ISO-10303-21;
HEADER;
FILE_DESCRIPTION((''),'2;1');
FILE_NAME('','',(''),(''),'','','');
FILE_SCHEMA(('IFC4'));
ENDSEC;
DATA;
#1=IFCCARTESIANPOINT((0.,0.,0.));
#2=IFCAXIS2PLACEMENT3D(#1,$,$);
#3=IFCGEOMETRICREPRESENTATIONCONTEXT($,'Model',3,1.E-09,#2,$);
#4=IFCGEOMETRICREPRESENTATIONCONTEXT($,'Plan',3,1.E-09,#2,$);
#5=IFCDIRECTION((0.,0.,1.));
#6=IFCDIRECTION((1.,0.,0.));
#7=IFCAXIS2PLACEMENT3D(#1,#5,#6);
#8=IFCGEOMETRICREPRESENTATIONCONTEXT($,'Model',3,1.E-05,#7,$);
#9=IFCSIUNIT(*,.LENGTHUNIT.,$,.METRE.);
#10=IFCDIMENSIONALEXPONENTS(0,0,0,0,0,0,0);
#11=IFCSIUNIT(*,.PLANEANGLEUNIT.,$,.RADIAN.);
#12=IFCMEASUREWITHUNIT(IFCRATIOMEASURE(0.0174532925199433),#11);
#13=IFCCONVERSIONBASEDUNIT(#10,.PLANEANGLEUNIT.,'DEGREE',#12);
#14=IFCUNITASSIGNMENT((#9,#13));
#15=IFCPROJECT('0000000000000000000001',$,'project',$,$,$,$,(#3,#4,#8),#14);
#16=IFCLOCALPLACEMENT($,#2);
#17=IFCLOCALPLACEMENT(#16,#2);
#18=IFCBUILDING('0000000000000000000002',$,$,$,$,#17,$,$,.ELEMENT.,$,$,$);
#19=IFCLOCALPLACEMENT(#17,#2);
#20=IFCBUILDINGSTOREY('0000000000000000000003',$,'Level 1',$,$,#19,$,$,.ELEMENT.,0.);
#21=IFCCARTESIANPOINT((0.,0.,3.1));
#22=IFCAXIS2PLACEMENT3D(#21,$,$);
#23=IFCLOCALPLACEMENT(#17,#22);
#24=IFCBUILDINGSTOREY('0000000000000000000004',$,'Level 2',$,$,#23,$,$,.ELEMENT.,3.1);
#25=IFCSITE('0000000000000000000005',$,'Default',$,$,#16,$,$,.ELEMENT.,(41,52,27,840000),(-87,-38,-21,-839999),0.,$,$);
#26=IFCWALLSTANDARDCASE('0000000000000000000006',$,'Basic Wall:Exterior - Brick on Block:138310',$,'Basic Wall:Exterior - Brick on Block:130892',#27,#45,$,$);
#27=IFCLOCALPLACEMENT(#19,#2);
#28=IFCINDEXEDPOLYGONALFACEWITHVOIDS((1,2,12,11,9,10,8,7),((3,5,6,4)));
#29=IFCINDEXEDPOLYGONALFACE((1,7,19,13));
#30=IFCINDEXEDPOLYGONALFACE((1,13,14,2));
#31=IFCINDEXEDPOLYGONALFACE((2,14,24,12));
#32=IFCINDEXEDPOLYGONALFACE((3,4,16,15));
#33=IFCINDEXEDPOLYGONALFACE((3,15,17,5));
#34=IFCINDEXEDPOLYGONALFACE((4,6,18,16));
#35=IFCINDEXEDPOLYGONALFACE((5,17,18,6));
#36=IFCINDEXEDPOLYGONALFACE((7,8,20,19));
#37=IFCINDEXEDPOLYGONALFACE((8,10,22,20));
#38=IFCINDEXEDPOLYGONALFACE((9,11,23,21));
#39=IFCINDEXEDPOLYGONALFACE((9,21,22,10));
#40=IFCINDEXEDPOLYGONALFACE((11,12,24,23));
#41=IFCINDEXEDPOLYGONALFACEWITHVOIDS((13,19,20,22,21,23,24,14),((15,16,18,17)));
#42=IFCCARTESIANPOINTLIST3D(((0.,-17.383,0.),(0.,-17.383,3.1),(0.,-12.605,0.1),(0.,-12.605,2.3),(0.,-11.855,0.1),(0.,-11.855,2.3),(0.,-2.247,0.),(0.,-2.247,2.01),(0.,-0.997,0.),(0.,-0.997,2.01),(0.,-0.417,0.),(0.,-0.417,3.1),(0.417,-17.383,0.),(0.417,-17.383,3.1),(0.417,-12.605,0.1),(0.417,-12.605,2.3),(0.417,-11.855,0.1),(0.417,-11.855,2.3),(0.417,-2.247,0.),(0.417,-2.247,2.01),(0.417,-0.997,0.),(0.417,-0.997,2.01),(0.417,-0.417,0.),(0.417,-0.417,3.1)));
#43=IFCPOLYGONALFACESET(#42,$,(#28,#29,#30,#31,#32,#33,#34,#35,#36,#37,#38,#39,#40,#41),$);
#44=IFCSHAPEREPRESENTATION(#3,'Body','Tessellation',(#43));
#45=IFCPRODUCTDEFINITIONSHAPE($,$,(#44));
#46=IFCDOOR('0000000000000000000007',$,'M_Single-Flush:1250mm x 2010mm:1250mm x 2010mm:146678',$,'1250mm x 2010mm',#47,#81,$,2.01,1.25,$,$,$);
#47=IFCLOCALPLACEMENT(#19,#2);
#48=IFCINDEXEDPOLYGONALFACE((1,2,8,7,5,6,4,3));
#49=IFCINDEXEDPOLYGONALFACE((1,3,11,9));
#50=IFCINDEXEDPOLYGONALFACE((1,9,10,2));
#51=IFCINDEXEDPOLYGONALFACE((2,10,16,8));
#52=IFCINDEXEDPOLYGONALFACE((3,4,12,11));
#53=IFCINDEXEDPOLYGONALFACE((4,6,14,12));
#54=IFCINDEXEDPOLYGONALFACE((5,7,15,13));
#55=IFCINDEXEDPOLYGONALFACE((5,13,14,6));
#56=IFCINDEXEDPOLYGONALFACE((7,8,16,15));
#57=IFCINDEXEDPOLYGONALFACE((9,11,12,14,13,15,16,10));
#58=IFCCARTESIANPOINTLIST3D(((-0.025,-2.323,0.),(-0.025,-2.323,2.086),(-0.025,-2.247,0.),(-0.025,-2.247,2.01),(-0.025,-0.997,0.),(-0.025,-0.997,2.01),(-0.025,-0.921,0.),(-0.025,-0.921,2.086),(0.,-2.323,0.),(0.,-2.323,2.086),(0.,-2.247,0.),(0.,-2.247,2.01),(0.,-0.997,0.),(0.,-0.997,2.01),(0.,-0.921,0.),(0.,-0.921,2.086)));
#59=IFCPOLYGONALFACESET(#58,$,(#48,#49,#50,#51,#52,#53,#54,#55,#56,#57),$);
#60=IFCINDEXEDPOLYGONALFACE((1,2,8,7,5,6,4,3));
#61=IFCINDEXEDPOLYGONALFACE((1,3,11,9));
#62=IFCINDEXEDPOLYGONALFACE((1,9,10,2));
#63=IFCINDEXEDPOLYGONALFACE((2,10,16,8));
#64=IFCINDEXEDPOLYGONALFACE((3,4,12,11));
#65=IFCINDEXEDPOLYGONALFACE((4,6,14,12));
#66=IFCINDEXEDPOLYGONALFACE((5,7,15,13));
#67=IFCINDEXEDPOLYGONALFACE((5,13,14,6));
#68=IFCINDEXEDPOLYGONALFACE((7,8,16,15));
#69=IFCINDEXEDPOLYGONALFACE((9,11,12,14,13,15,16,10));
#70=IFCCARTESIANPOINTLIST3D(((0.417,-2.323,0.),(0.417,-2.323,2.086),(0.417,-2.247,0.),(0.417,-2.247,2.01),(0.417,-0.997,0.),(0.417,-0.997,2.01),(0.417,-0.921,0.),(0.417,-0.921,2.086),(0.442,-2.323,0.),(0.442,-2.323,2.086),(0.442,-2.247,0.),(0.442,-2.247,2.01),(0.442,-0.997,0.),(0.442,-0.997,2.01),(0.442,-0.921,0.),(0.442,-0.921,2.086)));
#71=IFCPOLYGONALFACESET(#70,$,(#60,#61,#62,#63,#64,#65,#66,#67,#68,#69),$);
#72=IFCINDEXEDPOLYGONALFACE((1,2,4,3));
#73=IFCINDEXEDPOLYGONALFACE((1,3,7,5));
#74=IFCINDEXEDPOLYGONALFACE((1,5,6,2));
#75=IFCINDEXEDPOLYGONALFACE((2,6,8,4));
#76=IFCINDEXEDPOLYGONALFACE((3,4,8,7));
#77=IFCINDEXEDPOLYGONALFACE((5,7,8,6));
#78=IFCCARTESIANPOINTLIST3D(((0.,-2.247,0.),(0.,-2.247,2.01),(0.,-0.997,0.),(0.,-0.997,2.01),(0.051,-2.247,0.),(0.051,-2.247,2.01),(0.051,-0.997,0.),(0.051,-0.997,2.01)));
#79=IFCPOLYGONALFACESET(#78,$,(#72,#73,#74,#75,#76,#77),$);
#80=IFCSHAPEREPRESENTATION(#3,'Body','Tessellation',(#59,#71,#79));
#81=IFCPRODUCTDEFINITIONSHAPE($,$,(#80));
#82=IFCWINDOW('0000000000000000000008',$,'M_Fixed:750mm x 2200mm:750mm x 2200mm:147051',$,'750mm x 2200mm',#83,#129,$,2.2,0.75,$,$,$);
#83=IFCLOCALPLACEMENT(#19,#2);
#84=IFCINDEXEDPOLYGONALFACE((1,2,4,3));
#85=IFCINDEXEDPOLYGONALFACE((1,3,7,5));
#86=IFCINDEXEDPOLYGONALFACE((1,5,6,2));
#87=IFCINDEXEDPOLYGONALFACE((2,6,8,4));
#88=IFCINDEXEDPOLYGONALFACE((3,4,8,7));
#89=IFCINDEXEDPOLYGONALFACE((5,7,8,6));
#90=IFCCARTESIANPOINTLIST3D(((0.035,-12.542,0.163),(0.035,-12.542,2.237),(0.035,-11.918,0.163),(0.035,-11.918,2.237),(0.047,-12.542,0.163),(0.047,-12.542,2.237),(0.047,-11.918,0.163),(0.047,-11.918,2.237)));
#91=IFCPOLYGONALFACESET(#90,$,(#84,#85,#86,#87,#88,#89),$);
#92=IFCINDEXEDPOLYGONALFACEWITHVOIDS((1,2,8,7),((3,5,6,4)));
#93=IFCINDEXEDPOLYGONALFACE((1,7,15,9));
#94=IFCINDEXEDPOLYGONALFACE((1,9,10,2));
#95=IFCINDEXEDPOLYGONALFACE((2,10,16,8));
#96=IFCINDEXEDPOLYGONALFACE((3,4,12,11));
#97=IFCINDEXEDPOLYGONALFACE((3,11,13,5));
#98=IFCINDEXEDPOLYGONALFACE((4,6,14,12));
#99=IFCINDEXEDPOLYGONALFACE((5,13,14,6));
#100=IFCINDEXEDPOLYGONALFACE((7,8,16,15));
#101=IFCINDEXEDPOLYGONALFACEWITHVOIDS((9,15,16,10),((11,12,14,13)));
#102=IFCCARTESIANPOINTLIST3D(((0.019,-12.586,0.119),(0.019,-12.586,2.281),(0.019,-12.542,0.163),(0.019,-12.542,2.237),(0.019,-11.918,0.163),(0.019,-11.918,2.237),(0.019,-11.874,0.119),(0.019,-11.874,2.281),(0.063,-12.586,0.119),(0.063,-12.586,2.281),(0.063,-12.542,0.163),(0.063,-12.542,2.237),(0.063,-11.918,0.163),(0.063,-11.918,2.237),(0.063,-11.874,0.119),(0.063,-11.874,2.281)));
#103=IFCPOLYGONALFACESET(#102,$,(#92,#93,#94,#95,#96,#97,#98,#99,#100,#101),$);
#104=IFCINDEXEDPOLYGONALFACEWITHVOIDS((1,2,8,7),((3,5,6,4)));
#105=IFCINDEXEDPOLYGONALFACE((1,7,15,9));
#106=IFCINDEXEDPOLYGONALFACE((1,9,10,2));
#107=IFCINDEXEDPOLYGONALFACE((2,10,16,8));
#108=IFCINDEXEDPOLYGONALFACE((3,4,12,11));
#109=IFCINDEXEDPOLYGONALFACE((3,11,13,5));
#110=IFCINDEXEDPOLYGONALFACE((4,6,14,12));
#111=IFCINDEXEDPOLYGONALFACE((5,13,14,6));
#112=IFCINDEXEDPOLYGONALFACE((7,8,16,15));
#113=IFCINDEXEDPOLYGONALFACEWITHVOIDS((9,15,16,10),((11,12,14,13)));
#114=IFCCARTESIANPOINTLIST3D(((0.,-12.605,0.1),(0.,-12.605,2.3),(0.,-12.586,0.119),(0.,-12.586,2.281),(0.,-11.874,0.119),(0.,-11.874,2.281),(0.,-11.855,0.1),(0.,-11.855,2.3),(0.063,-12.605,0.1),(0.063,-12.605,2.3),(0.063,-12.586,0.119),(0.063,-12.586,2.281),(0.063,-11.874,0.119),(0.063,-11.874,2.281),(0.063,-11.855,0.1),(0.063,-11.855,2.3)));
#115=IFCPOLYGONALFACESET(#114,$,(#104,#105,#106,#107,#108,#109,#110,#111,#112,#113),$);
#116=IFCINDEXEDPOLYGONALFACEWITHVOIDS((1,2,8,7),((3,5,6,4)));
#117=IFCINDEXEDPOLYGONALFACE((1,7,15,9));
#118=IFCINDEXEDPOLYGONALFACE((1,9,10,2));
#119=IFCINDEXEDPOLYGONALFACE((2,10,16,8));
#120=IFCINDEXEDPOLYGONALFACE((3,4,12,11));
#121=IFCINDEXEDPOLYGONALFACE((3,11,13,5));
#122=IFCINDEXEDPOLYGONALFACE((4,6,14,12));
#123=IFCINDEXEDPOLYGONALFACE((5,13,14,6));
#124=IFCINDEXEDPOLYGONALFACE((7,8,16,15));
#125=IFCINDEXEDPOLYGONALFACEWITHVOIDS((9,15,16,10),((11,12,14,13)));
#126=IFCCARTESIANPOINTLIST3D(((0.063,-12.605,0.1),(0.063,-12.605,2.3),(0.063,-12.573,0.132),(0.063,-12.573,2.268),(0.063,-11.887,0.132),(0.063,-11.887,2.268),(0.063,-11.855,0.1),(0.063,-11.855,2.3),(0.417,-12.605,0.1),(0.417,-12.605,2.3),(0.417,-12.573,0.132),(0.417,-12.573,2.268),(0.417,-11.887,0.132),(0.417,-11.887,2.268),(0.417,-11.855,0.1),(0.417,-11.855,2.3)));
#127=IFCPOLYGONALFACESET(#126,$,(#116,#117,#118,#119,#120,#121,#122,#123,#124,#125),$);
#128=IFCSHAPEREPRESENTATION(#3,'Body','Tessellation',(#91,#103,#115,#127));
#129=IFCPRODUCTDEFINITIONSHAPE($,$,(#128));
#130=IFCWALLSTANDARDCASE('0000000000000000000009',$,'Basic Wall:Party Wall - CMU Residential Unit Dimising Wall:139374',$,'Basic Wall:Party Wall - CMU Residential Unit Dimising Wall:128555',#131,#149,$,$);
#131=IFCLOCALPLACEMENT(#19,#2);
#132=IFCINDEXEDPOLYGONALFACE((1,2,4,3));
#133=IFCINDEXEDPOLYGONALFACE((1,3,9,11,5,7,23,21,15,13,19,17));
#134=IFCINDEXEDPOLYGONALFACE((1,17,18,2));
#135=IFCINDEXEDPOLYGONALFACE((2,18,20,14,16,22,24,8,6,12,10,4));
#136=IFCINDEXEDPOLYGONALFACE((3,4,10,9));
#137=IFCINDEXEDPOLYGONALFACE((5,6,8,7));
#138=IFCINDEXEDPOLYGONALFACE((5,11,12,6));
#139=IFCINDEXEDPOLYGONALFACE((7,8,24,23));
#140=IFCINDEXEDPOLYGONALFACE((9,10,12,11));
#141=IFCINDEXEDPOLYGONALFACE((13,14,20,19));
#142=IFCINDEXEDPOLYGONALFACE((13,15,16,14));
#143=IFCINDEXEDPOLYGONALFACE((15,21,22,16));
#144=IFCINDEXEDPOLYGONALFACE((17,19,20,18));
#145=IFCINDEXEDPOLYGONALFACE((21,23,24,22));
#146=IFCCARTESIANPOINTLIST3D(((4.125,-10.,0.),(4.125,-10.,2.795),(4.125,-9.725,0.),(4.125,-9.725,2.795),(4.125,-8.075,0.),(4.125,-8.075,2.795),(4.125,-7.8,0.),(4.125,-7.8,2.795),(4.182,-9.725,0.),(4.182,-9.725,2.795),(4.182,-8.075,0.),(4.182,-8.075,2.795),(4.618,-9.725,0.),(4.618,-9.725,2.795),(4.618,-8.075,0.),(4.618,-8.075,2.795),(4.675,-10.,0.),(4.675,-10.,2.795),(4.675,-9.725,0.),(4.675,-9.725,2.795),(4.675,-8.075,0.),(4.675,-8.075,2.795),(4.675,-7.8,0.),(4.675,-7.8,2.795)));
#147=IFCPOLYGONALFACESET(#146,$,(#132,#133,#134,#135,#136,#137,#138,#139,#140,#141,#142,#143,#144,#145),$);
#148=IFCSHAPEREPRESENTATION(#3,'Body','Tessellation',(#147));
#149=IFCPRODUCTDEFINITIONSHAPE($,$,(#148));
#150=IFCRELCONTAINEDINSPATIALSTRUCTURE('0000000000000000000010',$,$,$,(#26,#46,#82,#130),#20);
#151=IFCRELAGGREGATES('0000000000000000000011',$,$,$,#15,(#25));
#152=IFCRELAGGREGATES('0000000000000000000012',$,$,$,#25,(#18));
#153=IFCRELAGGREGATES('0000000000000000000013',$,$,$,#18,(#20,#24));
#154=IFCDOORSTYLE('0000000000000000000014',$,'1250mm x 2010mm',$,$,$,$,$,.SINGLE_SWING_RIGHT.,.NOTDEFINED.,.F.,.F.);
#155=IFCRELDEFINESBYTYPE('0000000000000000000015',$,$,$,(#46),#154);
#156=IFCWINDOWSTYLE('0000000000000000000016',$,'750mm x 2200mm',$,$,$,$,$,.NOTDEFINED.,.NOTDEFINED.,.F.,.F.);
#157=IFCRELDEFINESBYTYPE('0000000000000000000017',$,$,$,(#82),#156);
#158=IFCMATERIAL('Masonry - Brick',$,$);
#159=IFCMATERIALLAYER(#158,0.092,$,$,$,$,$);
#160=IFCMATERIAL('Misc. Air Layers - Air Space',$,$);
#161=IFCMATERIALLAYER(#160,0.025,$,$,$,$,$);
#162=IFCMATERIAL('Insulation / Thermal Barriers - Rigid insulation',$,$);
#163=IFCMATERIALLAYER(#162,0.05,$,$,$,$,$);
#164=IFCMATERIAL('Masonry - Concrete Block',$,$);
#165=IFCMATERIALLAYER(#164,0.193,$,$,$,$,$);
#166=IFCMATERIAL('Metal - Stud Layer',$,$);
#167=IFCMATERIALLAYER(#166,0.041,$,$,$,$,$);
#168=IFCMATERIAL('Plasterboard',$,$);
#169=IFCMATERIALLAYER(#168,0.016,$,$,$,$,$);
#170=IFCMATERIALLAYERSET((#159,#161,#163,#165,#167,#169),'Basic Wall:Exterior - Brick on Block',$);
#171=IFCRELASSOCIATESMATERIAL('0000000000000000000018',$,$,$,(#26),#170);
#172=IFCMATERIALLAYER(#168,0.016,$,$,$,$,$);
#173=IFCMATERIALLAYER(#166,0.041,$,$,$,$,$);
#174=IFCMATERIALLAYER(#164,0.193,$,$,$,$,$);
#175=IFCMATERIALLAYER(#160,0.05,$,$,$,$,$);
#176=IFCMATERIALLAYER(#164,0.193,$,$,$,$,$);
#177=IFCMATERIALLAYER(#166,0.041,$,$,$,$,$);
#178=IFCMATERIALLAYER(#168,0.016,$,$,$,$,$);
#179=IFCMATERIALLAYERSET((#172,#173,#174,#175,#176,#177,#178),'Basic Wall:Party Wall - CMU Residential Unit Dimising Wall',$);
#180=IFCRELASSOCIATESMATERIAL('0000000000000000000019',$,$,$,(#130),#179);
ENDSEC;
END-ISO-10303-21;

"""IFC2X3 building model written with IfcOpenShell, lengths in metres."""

from ifc_helpers import new_model, entity, si_unit, converted_unit, frame, frame_2d, origin, origin_with_axes, origin_2d_with_axis, place, context, project, spatial, polyline, rectangle, outline, extrude, clip, bounded_halfspace, source, transform, mapped, material, layer, layer_set, layer_usage, type_object, type_shapes, element, fill, save


model = new_model("IFC2X3")

# Units and contexts
model_context_1 = context("Model", 3, precision=1e-09, world=origin())
plan_context = context("Plan", 3, precision=1e-09, world=origin())
model_context_2 = context("Model", 3, precision=1e-05, world=origin_with_axes())
ifc_project = project(units=[si_unit("LENGTHUNIT", "METRE"), converted_unit("PLANEANGLEUNIT", "DEGREE", entity("IfcRatioMeasure", 0.0174532925199433), si_unit("PLANEANGLEUNIT", "RADIAN"), dimensions=[0, 0, 0, 0, 0, 0, 0])], contexts=[model_context_1, plan_context, model_context_2])

# Site, building, storey
site_placement = place(None, origin())
site = spatial("IfcSite", under=ifc_project, at=site_placement, Name="Default", CompositionType="ELEMENT", RefLatitude=(41, 52, 27, 840000), RefLongitude=(-87, -38, -21, -839999), RefElevation=0.0)
building_placement = place(site_placement, origin())
building = spatial("IfcBuilding", under=site, at=building_placement, CompositionType="ELEMENT")
storey_1_placement = place(building_placement, origin())
storey_1 = spatial("IfcBuildingStorey", under=building, at=storey_1_placement, Name="Level 1", CompositionType="ELEMENT", Elevation=0.0)

# Shared definitions
ifc_material_1 = material(Name="Masonry - Brick")
ifc_layer_1 = layer(ifc_material_1, 0.092)
ifc_material_2 = material(Name="Misc. Air Layers - Air Space")
ifc_layer_2 = layer(ifc_material_2, 0.025)
ifc_material_3 = material(Name="Insulation / Thermal Barriers - Rigid insulation")
ifc_layer_3 = layer(ifc_material_3, 0.05)
ifc_material_4 = material(Name="Masonry - Concrete Block")
ifc_layer_4 = layer(ifc_material_4, 0.193)
ifc_material_5 = material(Name="Metal - Stud Layer")
ifc_layer_5 = layer(ifc_material_5, 0.041)
ifc_material_6 = material(Name="Plasterboard")
ifc_layer_6 = layer(ifc_material_6, 0.016)
ifc_layer_set_1 = layer_set([ifc_layer_1, ifc_layer_2, ifc_layer_3, ifc_layer_4, ifc_layer_5, ifc_layer_6], Name="Basic Wall:Exterior - Brick on Block")

# Wall, openings, door, window
ifc_layer_usage_1 = layer_usage(ifc_layer_set_1, "AXIS2", "NEGATIVE", 0.2085)
wall_1_placement = place(storey_1_placement, frame((0.2085, -17.383, 0.0), z_axis=(0.0, 0.0, 1.0), x_axis=(0.0, 1.0, 0.0)))
wall_1 = element("IfcWallStandardCase", 1, at=wall_1_placement, inside=storey_1, material=ifc_layer_usage_1, Name="Basic Wall:Exterior - Brick on Block:138310", ObjectType="Basic Wall:Exterior - Brick on Block:130892", context=model_context_1, shape_type="SweptSolid", body=[
    extrude(rectangle(XDim=16.966, YDim=0.417, at=frame_2d((8.483, 0.0), x_axis=(-1.0, 0.0))), origin(), (0.0, 0.0, 1.0), 3.1),
])
opening_1_placement = place(wall_1_placement, frame((15.136, -0.2085, 0.0)))
opening_1 = element("IfcOpeningElement", 2, at=opening_1_placement, cuts=wall_1, ObjectType="Opening", context=model_context_1, shape_type="SweptSolid", body=[
    extrude(rectangle(XDim=1.25, YDim=2.01, at=frame_2d((1.005, 0.625), x_axis=(0.0, 1.0))), frame((0.0, 0.0, 0.0), z_axis=(0.0, 1.0, 0.0), x_axis=(0.0, 0.0, 1.0)), (0.0, 0.0, 1.0), 0.417),
])
opening_2_placement = place(wall_1_placement, frame((4.778, -0.2085, 0.1)))
opening_2 = element("IfcOpeningElement", 3, at=opening_2_placement, cuts=wall_1, ObjectType="Opening", context=model_context_1, shape_type="SweptSolid", body=[
    extrude(rectangle(XDim=2.2, YDim=0.75, at=frame_2d((1.1, 0.375), x_axis=(1.0, 0.0))), frame((0.0, 0.0, 0.0), z_axis=(0.0, 1.0, 0.0), x_axis=(0.0, 0.0, 1.0)), (0.0, 0.0, 1.0), 0.417),
])
door_style_1 = type_object("IfcDoorStyle", Name="1250mm x 2010mm", ConstructionType="NOTDEFINED", OperationType="SINGLE_SWING_RIGHT", ParameterTakesPrecedence=False, Sizeable=False)
shared_shape_1 = source(origin(), model_context_1, "Body", "SweptSolid", [
    extrude(outline(polyline([(-0.701, -1.062), (0.701, -1.062), (0.701, 1.024), (0.625, 1.024), (0.625, -0.986), (-0.625, -0.986), (-0.625, 1.024), (-0.701, 1.024), (-0.701, -1.062)])), frame((0.625, 0.417, 1.024), z_axis=(0.0, 1.0, 0.0), x_axis=(1.0, 0.0, 0.0)), (0.0, 0.0, 1.0), 0.025),
    extrude(outline(polyline([(-1.062, -0.701), (1.024, -0.701), (1.024, -0.625), (-0.986, -0.625), (-0.986, 0.625), (1.024, 0.625), (1.024, 0.701), (-1.062, 0.701), (-1.062, -0.701)])), frame((0.625, -0.025, 1.024), z_axis=(0.0, 1.0, 0.0), x_axis=(0.0, 0.0, -1.0)), (0.0, 0.0, 1.0), 0.025),
    extrude(rectangle(XDim=0.051, YDim=1.25, at=origin_2d_with_axis()), frame((0.625, 0.3915, 0.0), z_axis=(0.0, 0.0, 1.0), x_axis=(0.0, 1.0, 0.0)), (0.0, 0.0, 1.0), 2.01),
])
type_shapes(door_style_1, [shared_shape_1])
door_1_placement = place(opening_1_placement, origin())
door_1 = element("IfcDoor", 4, at=door_1_placement, inside=storey_1, type_object=door_style_1, Name="M_Single-Flush:1250mm x 2010mm:1250mm x 2010mm:146678", ObjectType="1250mm x 2010mm", OverallHeight=2.01, OverallWidth=1.25, context=model_context_1, shape_type="MappedRepresentation", body=[
    mapped(shared_shape_1, transform((0.0, 0.0, 0.0), scale=1.0)),
])
fill(opening_1, door_1)
window_style_1 = type_object("IfcWindowStyle", Name="750mm x 2200mm", ConstructionType="NOTDEFINED", OperationType="NOTDEFINED", ParameterTakesPrecedence=False, Sizeable=False)
shared_shape_2 = source(origin(), model_context_1, "Body", "SweptSolid", [
    extrude(rectangle(XDim=0.012, YDim=0.624, at=origin_2d_with_axis()), frame((0.375, 0.376, 0.063), z_axis=(0.0, 0.0, 1.0), x_axis=(0.0, -1.0, 0.0)), (0.0, 0.0, 1.0), 2.074),
    extrude(outline(polyline([(-0.356, -1.081), (0.356, -1.081), (0.356, 1.081), (-0.356, 1.081), (-0.356, -1.081)]), holes=[polyline([(-0.312, -1.037), (-0.312, 1.037), (0.312, 1.037), (0.312, -1.037), (-0.312, -1.037)])]), frame((0.375, 0.354, 1.1), z_axis=(0.0, 1.0, 0.0), x_axis=(1.0, 0.0, 0.0)), (0.0, 0.0, 1.0), 0.044),
    extrude(outline(polyline([(-0.375, -1.1), (0.375, -1.1), (0.375, 1.1), (-0.375, 1.1), (-0.375, -1.1)]), holes=[polyline([(-0.356, -1.081), (-0.356, 1.081), (0.356, 1.081), (0.356, -1.081), (-0.356, -1.081)])]), frame((0.375, 0.354, 1.1), z_axis=(0.0, 1.0, 0.0), x_axis=(1.0, 0.0, 0.0)), (0.0, 0.0, 1.0), 0.063),
    extrude(outline(polyline([(-0.375, -1.1), (0.375, -1.1), (0.375, 1.1), (-0.375, 1.1), (-0.375, -1.1)]), holes=[polyline([(-0.343, -1.068), (-0.343, 1.068), (0.343, 1.068), (0.343, -1.068), (-0.343, -1.068)])]), frame((0.375, 0.0, 1.1), z_axis=(0.0, 1.0, 0.0), x_axis=(1.0, 0.0, 0.0)), (0.0, 0.0, 1.0), 0.354),
])
type_shapes(window_style_1, [shared_shape_2])
window_1_placement = place(opening_2_placement, origin())
window_1 = element("IfcWindow", 5, at=window_1_placement, inside=storey_1, type_object=window_style_1, Name="M_Fixed:750mm x 2200mm:750mm x 2200mm:147051", ObjectType="750mm x 2200mm", OverallHeight=2.2, OverallWidth=0.75, context=model_context_1, shape_type="MappedRepresentation", body=[
    mapped(shared_shape_2, transform((0.0, 0.0, 0.0), scale=1.0)),
])
fill(opening_2, window_1)

# Wall
ifc_layer_7 = layer(ifc_material_6, 0.016)
ifc_layer_8 = layer(ifc_material_5, 0.041)
ifc_layer_9 = layer(ifc_material_4, 0.193)
ifc_layer_10 = layer(ifc_material_2, 0.05)
ifc_layer_11 = layer(ifc_material_4, 0.193)
ifc_layer_12 = layer(ifc_material_5, 0.041)
ifc_layer_13 = layer(ifc_material_6, 0.016)
ifc_layer_set_2 = layer_set([ifc_layer_7, ifc_layer_8, ifc_layer_9, ifc_layer_10, ifc_layer_11, ifc_layer_12, ifc_layer_13], Name="Basic Wall:Party Wall - CMU Residential Unit Dimising Wall")
ifc_layer_usage_2 = layer_usage(ifc_layer_set_2, "AXIS2", "NEGATIVE", 0.275)
wall_2_placement = place(storey_1_placement, frame((4.4, -10.0, 0.0), z_axis=(0.0, 0.0, 1.0), x_axis=(0.0, 1.0, 0.0)))
element("IfcWallStandardCase", 6, at=wall_2_placement, inside=storey_1, material=ifc_layer_usage_2, Name="Basic Wall:Party Wall - CMU Residential Unit Dimising Wall:139374", ObjectType="Basic Wall:Party Wall - CMU Residential Unit Dimising Wall:128555", context=model_context_1, shape_type="Clipping", body=[
    clip(clip(extrude(rectangle(XDim=2.2, YDim=0.55, at=frame_2d((1.1, 0.0), x_axis=(-1.0, 0.0))), origin(), (0.0, 0.0, 1.0), 2.795), bounded_halfspace(frame((1.925, 0.218, 0.0), z_axis=(0.0, -1.0, 0.0), x_axis=(1.0, 0.0, 0.0)), True, frame((1.925, 0.218, 0.0), z_axis=(0.0, -1.0, 0.0), x_axis=(1.0, 0.0, 0.0)), polyline([(0.0, 0.0), (0.0, 2.795), (-1.65, 2.795), (-1.65, 0.0), (0.0, 0.0)]))), bounded_halfspace(frame((0.275, -0.218, 0.0), z_axis=(0.0, 1.0, 0.0), x_axis=(-1.0, 0.0, 0.0)), True, frame((0.275, -0.218, 0.0), z_axis=(0.0, 1.0, 0.0), x_axis=(-1.0, 0.0, 0.0)), polyline([(0.0, 0.0), (0.0, 2.795), (-1.65, 2.795), (-1.65, 0.0), (0.0, 0.0)]))),
])

# Shared definitions
storey_2_placement = place(building_placement, frame((0.0, 0.0, 3.1)))
storey_2 = spatial("IfcBuildingStorey", under=building, at=storey_2_placement, Name="Level 2", CompositionType="ELEMENT", Elevation=3.1)

save(model, "model.ifc")
